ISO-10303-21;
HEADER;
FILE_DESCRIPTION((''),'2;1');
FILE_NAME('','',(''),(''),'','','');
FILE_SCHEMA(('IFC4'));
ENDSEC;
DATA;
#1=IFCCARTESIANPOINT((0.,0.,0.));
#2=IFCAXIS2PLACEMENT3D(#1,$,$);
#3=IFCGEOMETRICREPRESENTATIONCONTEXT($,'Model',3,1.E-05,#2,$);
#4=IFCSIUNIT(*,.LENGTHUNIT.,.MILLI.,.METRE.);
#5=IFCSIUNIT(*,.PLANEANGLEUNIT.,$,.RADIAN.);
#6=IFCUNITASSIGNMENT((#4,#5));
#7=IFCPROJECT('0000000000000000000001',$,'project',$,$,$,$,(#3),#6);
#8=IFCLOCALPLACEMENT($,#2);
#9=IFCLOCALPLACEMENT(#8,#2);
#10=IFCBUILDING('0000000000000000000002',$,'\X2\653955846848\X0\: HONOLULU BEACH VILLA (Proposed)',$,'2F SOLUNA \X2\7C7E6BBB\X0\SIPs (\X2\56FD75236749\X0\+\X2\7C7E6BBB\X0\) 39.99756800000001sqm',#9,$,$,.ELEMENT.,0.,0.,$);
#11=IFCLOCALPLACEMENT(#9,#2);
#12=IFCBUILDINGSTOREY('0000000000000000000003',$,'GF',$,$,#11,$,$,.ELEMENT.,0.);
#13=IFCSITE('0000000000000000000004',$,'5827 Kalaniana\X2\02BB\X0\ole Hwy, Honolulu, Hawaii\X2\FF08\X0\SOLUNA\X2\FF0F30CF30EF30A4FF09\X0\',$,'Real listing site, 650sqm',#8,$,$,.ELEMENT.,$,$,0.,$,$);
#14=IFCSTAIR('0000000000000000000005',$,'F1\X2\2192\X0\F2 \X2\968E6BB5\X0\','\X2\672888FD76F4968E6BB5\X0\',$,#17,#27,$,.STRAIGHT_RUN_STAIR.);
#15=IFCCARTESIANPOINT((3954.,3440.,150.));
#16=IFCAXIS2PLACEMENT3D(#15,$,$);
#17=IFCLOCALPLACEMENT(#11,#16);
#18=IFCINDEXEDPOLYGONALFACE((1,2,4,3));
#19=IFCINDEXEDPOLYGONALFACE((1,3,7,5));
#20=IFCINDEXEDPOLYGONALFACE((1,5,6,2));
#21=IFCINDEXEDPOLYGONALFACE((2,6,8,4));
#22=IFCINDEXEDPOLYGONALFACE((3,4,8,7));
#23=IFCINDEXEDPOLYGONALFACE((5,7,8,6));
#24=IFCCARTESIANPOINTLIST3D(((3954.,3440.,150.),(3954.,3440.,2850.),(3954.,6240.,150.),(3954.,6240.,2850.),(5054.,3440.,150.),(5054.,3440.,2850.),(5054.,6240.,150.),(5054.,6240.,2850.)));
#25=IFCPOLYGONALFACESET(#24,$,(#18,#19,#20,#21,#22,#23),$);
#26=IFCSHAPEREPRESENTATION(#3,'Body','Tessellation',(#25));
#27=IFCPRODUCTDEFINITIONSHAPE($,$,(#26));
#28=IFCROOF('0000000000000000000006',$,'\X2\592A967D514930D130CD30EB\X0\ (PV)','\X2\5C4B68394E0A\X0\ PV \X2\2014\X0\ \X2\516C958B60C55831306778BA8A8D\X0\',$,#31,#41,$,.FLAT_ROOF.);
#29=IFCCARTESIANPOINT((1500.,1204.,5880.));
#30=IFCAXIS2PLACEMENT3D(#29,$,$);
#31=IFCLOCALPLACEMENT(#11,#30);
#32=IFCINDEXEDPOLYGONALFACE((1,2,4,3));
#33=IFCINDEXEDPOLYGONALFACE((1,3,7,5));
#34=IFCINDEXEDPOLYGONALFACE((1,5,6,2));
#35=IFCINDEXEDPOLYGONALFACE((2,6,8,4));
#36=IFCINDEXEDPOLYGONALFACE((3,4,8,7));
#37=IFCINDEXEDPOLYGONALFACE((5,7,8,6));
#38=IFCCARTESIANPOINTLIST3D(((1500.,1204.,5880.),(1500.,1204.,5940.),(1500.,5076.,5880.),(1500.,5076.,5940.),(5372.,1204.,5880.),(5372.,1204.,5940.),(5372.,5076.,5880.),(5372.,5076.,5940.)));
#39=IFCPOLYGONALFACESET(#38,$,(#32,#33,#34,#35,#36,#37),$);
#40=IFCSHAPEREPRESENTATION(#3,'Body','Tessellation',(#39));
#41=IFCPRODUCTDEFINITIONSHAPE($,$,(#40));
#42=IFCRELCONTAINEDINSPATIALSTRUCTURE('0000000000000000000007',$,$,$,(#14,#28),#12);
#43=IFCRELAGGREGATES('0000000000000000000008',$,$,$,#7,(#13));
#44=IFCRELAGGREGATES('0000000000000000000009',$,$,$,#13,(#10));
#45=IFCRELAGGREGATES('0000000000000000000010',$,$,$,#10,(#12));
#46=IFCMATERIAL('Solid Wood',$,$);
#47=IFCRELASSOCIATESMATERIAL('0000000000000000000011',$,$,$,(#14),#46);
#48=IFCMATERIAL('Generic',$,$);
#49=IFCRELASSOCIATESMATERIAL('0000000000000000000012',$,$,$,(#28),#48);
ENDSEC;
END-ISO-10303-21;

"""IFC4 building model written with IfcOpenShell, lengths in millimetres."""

from ifc_helpers import new_model, si_unit, frame, frame_2d, origin, place, context, project, spatial, rectangle, extrude, material, element, save


model = new_model("IFC4")

# Units and contexts
model_context = context("Model", 3, precision=1e-05, world=origin())
ifc_project = project(units=[si_unit("LENGTHUNIT", "METRE", prefix="MILLI"), si_unit("PLANEANGLEUNIT", "RADIAN")], contexts=[model_context])

# Site, building, storey
site_placement = place(None, origin())
site = spatial("IfcSite", under=ifc_project, at=site_placement, Name="5827 Kalanianaʻole Hwy, Honolulu, Hawaii（SOLUNA／ハワイ）", ObjectType="Real listing site, 650sqm", CompositionType="ELEMENT", RefElevation=0.0)
building_placement = place(site_placement, origin())
building = spatial("IfcBuilding", under=site, at=building_placement, Name="改善案: HONOLULU BEACH VILLA (Proposed)", ObjectType="2F SOLUNA 籾殻SIPs (国産杉+籾殻) 39.99756800000001sqm", CompositionType="ELEMENT", ElevationOfRefHeight=0.0, ElevationOfTerrain=0.0)
storey_placement = place(building_placement, origin())
storey = spatial("IfcBuildingStorey", under=building, at=storey_placement, Name="GF", CompositionType="ELEMENT", Elevation=0.0)

# Shared definitions
ifc_material_1 = material(Name="Generic")

# Stair
ifc_material_2 = material(Name="Solid Wood")
stair_placement = place(storey_placement, frame((3954.0, 3440.0, 150.0)))
element("IfcStair", 1, at=stair_placement, inside=storey, material=ifc_material_2, Name="F1→F2 階段", Description="木製直階段", PredefinedType="STRAIGHT_RUN_STAIR", context=model_context, shape_type="SweptSolid", body=[
    extrude(rectangle(XDim=1100.0, YDim=2800.0, at=frame_2d((550.0, 1400.0))), frame((3954.0, 3440.0, 150.0)), (0.0, 0.0, 1.0), 2700.0),
])

# Roof
roof_placement = place(storey_placement, frame((1500.0, 1204.0, 5880.0)))
element("IfcRoof", 2, at=roof_placement, inside=storey, material=ifc_material_1, Name="太陽光パネル (PV)", Description="屋根上 PV — 公開情報で確認", PredefinedType="FLAT_ROOF", context=model_context, shape_type="SweptSolid", body=[
    extrude(rectangle(XDim=3872.0, YDim=3872.0, at=frame_2d((1936.0, 1936.0))), frame((1500.0, 1204.0, 5880.0)), (0.0, 0.0, 1.0), 60.0),
])

save(model, "model.ifc")
